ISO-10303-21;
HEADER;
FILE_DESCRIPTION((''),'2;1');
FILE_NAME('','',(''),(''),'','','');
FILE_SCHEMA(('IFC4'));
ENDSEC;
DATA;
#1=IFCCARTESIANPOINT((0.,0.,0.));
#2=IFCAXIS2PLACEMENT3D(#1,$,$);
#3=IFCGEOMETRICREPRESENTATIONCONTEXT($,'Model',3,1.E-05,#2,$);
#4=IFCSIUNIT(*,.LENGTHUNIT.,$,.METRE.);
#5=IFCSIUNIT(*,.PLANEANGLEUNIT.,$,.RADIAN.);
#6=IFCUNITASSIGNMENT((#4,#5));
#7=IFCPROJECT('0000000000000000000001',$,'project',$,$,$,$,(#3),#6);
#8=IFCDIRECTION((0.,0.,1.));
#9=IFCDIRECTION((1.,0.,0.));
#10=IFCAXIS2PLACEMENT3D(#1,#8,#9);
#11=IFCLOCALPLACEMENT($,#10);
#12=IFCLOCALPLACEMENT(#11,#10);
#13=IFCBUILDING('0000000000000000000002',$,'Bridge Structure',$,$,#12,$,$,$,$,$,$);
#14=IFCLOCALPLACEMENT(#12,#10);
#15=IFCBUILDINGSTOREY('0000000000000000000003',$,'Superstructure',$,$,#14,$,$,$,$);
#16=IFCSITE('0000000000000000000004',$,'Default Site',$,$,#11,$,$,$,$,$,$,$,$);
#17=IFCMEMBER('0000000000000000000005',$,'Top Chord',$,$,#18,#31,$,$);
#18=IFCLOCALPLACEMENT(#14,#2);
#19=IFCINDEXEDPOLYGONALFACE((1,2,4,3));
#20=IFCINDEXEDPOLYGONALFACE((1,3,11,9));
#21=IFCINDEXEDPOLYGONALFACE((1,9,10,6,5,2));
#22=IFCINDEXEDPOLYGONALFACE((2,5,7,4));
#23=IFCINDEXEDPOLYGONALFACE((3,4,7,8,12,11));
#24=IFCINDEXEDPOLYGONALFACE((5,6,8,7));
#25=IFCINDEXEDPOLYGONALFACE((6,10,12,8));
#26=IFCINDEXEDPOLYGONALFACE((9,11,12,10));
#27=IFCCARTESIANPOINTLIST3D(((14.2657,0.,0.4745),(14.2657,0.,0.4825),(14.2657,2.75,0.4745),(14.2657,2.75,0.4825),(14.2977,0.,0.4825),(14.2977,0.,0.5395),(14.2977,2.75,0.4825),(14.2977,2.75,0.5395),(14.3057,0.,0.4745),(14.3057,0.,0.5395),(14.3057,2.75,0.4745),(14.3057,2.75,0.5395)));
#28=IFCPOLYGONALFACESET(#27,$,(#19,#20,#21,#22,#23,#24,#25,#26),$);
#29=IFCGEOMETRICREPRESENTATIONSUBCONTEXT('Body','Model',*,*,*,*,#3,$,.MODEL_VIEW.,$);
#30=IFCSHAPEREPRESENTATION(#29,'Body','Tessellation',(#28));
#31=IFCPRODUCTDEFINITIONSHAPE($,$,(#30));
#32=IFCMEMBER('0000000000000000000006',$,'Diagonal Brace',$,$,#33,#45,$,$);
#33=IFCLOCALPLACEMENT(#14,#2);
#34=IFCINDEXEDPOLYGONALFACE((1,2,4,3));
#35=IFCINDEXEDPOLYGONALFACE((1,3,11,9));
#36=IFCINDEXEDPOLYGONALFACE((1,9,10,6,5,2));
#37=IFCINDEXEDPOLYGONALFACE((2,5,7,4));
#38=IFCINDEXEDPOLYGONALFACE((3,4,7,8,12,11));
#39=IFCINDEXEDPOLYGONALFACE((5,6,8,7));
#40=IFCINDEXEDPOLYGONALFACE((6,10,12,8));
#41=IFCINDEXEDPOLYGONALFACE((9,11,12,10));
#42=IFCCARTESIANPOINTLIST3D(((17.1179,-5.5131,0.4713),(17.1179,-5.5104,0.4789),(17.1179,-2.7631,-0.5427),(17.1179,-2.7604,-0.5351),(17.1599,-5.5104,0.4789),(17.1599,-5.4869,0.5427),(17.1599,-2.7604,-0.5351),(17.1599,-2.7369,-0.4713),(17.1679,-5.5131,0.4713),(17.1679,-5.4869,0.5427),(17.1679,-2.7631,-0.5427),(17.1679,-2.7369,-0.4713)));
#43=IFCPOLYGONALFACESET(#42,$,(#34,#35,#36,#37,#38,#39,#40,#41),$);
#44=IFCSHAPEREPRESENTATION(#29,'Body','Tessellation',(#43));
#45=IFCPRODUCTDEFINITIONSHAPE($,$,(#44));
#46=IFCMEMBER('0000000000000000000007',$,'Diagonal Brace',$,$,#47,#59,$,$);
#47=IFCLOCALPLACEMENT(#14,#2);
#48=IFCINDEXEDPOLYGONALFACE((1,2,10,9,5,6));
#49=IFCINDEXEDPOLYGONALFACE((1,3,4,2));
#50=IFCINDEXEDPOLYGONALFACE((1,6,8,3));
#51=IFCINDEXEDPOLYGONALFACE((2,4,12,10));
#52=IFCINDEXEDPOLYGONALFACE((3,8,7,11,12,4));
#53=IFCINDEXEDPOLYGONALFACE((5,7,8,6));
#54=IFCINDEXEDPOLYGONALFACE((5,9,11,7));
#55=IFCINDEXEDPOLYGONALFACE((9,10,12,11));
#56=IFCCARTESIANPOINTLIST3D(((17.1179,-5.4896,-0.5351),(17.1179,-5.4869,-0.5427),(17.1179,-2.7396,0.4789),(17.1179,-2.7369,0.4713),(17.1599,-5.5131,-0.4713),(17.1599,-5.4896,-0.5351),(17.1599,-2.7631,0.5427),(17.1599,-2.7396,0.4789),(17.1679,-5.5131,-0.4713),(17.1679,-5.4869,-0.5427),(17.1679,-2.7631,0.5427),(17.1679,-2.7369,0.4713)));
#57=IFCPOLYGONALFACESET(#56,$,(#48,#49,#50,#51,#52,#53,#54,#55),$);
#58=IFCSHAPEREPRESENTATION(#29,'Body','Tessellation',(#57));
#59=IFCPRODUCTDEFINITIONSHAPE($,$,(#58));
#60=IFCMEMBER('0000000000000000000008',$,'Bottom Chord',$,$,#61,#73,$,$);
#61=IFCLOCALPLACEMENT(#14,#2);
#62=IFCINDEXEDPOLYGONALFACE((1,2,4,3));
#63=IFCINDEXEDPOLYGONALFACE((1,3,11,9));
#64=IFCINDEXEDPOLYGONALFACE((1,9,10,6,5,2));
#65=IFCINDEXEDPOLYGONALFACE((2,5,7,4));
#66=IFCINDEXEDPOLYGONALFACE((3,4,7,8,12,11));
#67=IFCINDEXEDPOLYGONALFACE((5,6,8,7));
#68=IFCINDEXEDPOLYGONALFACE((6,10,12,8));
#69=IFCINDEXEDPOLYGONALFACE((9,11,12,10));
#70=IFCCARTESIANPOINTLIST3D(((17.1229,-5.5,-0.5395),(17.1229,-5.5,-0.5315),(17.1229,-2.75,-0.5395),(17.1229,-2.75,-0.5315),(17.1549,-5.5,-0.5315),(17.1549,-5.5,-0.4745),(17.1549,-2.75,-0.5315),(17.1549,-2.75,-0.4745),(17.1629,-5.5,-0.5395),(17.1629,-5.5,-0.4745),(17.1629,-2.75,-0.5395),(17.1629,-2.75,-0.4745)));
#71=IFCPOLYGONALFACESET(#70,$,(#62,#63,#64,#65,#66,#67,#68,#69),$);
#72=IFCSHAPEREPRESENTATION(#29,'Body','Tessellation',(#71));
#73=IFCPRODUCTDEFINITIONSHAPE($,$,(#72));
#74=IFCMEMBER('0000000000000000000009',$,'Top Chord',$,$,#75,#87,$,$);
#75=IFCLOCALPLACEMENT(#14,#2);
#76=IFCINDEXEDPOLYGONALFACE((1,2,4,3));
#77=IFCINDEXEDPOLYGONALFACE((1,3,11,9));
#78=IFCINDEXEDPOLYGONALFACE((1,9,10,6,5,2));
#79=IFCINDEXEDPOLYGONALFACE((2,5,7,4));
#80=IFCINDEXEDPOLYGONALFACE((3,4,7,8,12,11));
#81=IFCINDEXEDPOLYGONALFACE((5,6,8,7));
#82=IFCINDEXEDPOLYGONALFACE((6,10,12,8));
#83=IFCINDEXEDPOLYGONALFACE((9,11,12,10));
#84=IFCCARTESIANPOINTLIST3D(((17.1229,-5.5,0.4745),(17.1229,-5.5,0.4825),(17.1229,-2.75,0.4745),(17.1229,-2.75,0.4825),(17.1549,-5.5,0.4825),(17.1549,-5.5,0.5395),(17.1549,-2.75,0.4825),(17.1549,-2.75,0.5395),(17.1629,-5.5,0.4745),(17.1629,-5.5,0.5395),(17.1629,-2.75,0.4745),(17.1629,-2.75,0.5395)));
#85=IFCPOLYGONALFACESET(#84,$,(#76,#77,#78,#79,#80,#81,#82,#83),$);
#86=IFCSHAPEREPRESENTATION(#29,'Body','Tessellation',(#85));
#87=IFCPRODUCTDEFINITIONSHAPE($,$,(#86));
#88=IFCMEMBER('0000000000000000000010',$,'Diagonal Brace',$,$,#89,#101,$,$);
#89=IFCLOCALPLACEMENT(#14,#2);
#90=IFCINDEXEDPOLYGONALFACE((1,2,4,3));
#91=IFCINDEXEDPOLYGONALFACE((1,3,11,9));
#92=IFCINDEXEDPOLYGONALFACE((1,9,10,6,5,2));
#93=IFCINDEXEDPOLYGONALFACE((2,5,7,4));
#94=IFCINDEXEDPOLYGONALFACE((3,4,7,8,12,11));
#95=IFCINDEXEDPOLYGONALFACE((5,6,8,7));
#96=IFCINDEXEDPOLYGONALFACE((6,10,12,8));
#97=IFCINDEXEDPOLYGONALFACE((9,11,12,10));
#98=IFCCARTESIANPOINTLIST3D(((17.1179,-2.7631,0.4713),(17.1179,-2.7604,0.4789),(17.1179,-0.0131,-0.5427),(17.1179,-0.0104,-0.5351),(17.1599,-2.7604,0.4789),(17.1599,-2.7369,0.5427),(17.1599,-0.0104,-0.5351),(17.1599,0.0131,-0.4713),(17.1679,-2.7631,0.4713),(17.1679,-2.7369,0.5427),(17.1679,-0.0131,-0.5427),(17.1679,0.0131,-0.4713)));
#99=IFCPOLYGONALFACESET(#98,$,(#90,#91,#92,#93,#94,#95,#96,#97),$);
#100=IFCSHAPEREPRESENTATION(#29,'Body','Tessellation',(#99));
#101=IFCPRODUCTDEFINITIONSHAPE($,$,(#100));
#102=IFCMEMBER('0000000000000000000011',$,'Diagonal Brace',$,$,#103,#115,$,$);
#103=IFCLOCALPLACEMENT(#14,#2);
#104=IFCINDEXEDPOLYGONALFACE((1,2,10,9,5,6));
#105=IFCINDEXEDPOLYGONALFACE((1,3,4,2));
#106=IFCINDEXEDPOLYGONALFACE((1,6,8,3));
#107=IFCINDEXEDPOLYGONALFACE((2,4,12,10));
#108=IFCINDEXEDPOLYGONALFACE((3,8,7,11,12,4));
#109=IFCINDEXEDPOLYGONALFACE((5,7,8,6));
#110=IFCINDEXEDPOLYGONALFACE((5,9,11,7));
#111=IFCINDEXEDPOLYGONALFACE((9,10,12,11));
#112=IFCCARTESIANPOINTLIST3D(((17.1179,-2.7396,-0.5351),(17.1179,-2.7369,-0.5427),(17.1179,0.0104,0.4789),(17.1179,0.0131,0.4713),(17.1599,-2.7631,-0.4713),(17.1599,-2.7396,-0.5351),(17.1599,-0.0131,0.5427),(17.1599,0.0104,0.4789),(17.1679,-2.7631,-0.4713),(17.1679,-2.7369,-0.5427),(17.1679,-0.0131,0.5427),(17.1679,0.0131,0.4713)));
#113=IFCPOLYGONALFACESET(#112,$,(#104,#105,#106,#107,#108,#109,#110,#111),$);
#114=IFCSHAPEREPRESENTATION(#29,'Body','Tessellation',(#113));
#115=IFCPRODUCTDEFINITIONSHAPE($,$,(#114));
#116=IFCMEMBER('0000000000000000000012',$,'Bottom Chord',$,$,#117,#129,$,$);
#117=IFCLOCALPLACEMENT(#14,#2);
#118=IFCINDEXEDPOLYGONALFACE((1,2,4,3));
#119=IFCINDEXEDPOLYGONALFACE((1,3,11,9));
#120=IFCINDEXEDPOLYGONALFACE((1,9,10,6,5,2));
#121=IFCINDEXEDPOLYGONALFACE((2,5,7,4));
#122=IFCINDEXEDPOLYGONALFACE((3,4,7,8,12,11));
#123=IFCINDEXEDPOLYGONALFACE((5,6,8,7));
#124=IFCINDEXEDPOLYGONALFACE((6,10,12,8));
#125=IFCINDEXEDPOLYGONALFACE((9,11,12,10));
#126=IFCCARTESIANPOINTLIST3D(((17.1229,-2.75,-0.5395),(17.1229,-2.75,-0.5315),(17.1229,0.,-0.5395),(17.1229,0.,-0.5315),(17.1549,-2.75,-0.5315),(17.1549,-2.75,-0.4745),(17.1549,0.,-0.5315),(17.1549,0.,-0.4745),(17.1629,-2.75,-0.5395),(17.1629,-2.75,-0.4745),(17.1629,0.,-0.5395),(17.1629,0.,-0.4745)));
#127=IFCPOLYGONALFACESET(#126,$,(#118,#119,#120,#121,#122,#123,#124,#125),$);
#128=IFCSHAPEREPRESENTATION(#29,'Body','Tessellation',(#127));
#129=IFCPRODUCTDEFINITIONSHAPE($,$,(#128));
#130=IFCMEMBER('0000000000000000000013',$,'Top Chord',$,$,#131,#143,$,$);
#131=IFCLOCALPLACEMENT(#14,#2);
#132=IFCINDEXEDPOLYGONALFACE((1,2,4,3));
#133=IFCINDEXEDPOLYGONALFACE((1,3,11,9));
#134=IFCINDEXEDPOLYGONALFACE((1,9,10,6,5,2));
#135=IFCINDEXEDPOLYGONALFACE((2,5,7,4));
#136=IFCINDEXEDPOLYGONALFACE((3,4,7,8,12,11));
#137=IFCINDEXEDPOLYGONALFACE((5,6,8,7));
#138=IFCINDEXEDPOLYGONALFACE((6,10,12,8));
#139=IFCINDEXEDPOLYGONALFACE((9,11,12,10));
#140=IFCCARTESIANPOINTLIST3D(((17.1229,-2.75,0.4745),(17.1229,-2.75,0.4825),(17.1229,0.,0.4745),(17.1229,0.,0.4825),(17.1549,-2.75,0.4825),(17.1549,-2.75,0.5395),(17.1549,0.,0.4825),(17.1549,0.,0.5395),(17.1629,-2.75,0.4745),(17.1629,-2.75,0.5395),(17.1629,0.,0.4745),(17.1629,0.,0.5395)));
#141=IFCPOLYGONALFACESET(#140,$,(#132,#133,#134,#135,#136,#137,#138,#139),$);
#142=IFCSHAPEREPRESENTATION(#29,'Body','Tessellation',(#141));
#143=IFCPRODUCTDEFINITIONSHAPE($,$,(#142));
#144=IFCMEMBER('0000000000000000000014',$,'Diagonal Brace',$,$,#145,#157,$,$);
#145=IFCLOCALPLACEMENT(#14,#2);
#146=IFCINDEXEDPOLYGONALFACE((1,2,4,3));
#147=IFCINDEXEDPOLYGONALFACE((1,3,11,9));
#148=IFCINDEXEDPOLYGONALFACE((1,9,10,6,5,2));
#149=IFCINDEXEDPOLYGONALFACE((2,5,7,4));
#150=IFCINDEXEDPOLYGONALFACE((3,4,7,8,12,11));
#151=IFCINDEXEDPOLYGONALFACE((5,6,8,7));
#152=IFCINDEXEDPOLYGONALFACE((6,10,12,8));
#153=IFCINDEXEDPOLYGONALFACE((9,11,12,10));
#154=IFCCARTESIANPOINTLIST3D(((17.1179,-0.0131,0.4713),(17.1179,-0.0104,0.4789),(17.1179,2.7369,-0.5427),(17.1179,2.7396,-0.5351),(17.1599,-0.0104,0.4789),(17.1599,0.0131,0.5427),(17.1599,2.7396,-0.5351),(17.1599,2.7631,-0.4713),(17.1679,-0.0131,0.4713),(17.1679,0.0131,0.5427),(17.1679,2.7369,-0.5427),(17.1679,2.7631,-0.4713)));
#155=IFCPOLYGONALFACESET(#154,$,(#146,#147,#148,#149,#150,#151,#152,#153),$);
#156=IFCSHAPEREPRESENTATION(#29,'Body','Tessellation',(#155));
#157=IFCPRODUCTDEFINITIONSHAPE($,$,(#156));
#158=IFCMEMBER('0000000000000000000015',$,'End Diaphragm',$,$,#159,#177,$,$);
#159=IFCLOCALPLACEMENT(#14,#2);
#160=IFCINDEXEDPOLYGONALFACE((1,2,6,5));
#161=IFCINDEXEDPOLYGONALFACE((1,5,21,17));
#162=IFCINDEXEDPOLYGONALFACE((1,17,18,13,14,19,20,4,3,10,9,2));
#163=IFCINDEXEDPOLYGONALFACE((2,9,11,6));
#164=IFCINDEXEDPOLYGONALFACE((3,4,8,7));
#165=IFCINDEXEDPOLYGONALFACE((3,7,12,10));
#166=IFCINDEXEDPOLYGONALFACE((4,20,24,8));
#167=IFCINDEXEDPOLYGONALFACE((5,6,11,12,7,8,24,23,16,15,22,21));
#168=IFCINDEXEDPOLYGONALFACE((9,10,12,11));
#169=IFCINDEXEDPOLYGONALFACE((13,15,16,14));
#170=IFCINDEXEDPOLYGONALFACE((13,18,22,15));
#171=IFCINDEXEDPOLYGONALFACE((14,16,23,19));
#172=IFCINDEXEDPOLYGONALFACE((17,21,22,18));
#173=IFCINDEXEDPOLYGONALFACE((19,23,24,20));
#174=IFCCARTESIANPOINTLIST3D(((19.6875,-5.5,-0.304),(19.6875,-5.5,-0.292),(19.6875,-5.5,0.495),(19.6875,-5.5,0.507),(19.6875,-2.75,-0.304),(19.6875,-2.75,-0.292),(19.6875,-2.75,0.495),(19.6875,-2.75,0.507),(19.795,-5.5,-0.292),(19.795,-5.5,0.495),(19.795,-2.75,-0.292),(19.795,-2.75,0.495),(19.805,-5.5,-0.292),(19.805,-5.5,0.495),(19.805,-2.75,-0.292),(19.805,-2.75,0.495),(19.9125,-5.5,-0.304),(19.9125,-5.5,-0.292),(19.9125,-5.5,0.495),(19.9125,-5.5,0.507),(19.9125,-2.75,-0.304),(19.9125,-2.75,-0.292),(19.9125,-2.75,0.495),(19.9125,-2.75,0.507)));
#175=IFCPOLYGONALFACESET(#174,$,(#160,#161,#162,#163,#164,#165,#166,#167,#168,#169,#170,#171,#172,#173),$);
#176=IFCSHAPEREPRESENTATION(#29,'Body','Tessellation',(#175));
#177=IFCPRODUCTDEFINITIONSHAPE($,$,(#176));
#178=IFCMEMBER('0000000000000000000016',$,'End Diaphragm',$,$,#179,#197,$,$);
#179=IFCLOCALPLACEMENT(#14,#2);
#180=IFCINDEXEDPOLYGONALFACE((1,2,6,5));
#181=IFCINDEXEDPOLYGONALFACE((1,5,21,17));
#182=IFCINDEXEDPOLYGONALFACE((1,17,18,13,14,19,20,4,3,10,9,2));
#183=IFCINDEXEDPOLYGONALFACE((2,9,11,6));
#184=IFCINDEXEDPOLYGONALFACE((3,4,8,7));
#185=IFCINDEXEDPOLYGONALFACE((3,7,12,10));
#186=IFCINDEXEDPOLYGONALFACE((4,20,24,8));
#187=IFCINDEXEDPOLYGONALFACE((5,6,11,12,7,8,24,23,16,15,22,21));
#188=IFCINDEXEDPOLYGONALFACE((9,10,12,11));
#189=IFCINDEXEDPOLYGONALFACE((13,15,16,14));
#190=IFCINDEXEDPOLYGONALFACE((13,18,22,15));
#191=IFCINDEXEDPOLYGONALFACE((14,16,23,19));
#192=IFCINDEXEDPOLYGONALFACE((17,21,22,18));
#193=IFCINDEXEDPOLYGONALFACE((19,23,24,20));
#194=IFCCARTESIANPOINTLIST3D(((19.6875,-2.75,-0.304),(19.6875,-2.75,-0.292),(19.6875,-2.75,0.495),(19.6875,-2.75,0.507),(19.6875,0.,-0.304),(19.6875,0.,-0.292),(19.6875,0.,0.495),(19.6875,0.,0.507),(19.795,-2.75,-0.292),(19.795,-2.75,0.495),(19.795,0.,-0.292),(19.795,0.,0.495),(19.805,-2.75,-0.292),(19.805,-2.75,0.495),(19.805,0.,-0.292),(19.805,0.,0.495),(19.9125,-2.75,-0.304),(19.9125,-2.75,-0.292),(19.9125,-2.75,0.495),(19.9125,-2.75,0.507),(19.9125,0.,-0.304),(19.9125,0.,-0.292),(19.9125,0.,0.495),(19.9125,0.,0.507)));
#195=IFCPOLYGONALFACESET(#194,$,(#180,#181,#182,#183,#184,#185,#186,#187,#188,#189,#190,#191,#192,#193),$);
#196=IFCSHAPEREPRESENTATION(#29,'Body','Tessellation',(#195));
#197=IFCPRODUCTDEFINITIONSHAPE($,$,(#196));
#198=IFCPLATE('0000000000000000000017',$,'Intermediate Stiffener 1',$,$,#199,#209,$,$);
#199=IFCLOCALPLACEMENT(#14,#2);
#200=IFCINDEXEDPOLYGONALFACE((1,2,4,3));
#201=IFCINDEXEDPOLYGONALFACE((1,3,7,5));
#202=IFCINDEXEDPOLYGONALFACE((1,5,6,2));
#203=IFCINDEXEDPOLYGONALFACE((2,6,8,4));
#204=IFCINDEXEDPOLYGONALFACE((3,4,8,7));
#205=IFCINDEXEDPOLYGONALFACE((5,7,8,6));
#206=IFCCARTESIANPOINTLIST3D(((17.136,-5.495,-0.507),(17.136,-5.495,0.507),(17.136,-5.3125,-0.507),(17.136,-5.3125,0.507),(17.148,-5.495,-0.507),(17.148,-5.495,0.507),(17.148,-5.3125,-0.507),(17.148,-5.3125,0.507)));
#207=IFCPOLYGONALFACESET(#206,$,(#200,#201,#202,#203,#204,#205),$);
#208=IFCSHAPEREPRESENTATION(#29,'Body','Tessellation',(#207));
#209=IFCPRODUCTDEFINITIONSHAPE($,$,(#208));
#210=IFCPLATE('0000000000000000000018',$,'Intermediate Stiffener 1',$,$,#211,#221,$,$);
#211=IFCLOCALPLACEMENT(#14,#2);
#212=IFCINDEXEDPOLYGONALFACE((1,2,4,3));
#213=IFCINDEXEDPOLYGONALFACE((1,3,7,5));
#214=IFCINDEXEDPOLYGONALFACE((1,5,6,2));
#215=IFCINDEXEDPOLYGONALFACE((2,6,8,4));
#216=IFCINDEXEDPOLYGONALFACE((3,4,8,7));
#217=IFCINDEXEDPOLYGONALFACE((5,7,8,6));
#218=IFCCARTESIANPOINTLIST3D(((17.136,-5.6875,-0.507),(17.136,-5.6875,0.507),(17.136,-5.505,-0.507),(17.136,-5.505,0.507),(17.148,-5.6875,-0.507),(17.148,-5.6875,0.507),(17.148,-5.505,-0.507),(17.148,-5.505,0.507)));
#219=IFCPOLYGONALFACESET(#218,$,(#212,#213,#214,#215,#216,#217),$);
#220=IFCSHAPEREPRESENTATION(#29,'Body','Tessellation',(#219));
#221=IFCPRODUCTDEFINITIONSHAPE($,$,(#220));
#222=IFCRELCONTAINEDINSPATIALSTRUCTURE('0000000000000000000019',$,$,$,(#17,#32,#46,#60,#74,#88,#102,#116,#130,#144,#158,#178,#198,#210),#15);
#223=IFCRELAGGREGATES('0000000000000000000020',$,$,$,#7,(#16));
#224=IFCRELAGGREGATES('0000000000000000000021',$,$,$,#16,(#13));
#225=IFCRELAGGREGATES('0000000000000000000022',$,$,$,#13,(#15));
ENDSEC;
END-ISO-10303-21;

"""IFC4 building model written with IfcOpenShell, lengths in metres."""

from ifc_helpers import new_model, si_unit, frame, origin, origin_with_axes, origin_2d_with_axis, place, context, subcontext, project, spatial, rectangle, i_section, l_section, extrude, element, save


model = new_model("IFC4")

# Units and contexts
model_context = context("Model", 3, precision=1e-05, world=origin())
body_context = subcontext(model_context, "Body", "Model", "MODEL_VIEW")
ifc_project = project(units=[si_unit("LENGTHUNIT", "METRE"), si_unit("PLANEANGLEUNIT", "RADIAN")], contexts=[model_context])

# Site, building, storey
site_placement = place(None, origin_with_axes())
site = spatial("IfcSite", under=ifc_project, at=site_placement, Name="Default Site")
building_placement = place(site_placement, origin_with_axes())
building = spatial("IfcBuilding", under=site, at=building_placement, Name="Bridge Structure")
storey_placement = place(building_placement, origin_with_axes())
storey = spatial("IfcBuildingStorey", under=building, at=storey_placement, Name="Superstructure")

# Members
member_1_placement = place(storey_placement, frame((14.2857, 0.0, 0.507), z_axis=(0.0, 1.0, 0.0), x_axis=(-1.0, 0.0, 0.0)))
element("IfcMember", 1, at=member_1_placement, inside=storey, Name="Top Chord", context=body_context, shape_type="SweptSolid", body=[
    extrude(l_section(Depth=0.065, Width=0.04, Thickness=0.008, at=origin_2d_with_axis()), origin_with_axes(), (0.0, 0.0, 1.0), 2.75),
])
for number, where, z_axis, x_axis, name in (
    (2, (17.1429, -5.5, 0.507), (0.0, 0.93825, -0.345958), (-1.0, 0.0, 0.0), "Diagonal Brace"),
    (3, (17.1429, -5.5, -0.507), (0.0, 0.93825, 0.345958), (-1.0, 0.0, 0.0), "Diagonal Brace"),
):
    element("IfcMember", number, at=place(storey_placement, frame(where, z_axis=z_axis, x_axis=x_axis)), inside=storey, Name=name, context=body_context, shape_type="SweptSolid", body=[
        extrude(l_section(Depth=0.076, Width=0.05, Thickness=0.008, at=origin_2d_with_axis()), origin_with_axes(), (0.0, 0.0, 1.0), 2.931),
    ])
for number, where, z_axis, x_axis, name in (
    (4, (17.1429, -5.5, -0.507), (0.0, 1.0, 0.0), (-1.0, 0.0, 0.0), "Bottom Chord"),
    (5, (17.1429, -5.5, 0.507), (0.0, 1.0, 0.0), (-1.0, 0.0, 0.0), "Top Chord"),
):
    element("IfcMember", number, at=place(storey_placement, frame(where, z_axis=z_axis, x_axis=x_axis)), inside=storey, Name=name, context=body_context, shape_type="SweptSolid", body=[
        extrude(l_section(Depth=0.065, Width=0.04, Thickness=0.008, at=origin_2d_with_axis()), origin_with_axes(), (0.0, 0.0, 1.0), 2.75),
    ])
for number, where, z_axis, x_axis, name in (
    (6, (17.1429, -2.75, 0.507), (0.0, 0.93825, -0.345958), (-1.0, 0.0, 0.0), "Diagonal Brace"),
    (7, (17.1429, -2.75, -0.507), (0.0, 0.93825, 0.345958), (-1.0, 0.0, 0.0), "Diagonal Brace"),
):
    element("IfcMember", number, at=place(storey_placement, frame(where, z_axis=z_axis, x_axis=x_axis)), inside=storey, Name=name, context=body_context, shape_type="SweptSolid", body=[
        extrude(l_section(Depth=0.076, Width=0.05, Thickness=0.008, at=origin_2d_with_axis()), origin_with_axes(), (0.0, 0.0, 1.0), 2.931),
    ])
for number, where, z_axis, x_axis, name in (
    (8, (17.1429, -2.75, -0.507), (0.0, 1.0, 0.0), (-1.0, 0.0, 0.0), "Bottom Chord"),
    (9, (17.1429, -2.75, 0.507), (0.0, 1.0, 0.0), (-1.0, 0.0, 0.0), "Top Chord"),
):
    element("IfcMember", number, at=place(storey_placement, frame(where, z_axis=z_axis, x_axis=x_axis)), inside=storey, Name=name, context=body_context, shape_type="SweptSolid", body=[
        extrude(l_section(Depth=0.065, Width=0.04, Thickness=0.008, at=origin_2d_with_axis()), origin_with_axes(), (0.0, 0.0, 1.0), 2.75),
    ])
member_2_placement = place(storey_placement, frame((17.1429, 0.0, 0.507), z_axis=(0.0, 0.93825, -0.345958), x_axis=(-1.0, 0.0, 0.0)))
element("IfcMember", 10, at=member_2_placement, inside=storey, Name="Diagonal Brace", context=body_context, shape_type="SweptSolid", body=[
    extrude(l_section(Depth=0.076, Width=0.05, Thickness=0.008, at=origin_2d_with_axis()), origin_with_axes(), (0.0, 0.0, 1.0), 2.931),
])
for number, where, z_axis, x_axis, name in (
    (11, (19.8, -5.5, 0.1015), (0.0, 1.0, 0.0), (-1.0, 0.0, 0.0), "End Diaphragm"),
    (12, (19.8, -2.75, 0.1015), (0.0, 1.0, 0.0), (-1.0, 0.0, 0.0), "End Diaphragm"),
):
    element("IfcMember", number, at=place(storey_placement, frame(where, z_axis=z_axis, x_axis=x_axis)), inside=storey, Name=name, context=body_context, shape_type="SweptSolid", body=[
        extrude(i_section(OverallWidth=0.225, OverallDepth=0.811, WebThickness=0.01, FlangeThickness=0.012, at=origin_2d_with_axis()), origin_with_axes(), (0.0, 0.0, 1.0), 2.75),
    ])

# Plates
for number, where, z_axis, x_axis, name in (
    (13, (17.142, -5.4038, -0.507), (0.0, 0.0, 1.0), (1.0, 0.0, 0.0), "Intermediate Stiffener 1"),
    (14, (17.142, -5.5963, -0.507), (0.0, 0.0, 1.0), (1.0, 0.0, 0.0), "Intermediate Stiffener 1"),
):
    element("IfcPlate", number, at=place(storey_placement, frame(where, z_axis=z_axis, x_axis=x_axis)), inside=storey, Name=name, context=body_context, shape_type="SweptSolid", body=[
        extrude(rectangle(XDim=0.012, YDim=0.1825, at=origin_2d_with_axis()), origin_with_axes(), (0.0, 0.0, 1.0), 1.014),
    ])

save(model, "model.ifc")
